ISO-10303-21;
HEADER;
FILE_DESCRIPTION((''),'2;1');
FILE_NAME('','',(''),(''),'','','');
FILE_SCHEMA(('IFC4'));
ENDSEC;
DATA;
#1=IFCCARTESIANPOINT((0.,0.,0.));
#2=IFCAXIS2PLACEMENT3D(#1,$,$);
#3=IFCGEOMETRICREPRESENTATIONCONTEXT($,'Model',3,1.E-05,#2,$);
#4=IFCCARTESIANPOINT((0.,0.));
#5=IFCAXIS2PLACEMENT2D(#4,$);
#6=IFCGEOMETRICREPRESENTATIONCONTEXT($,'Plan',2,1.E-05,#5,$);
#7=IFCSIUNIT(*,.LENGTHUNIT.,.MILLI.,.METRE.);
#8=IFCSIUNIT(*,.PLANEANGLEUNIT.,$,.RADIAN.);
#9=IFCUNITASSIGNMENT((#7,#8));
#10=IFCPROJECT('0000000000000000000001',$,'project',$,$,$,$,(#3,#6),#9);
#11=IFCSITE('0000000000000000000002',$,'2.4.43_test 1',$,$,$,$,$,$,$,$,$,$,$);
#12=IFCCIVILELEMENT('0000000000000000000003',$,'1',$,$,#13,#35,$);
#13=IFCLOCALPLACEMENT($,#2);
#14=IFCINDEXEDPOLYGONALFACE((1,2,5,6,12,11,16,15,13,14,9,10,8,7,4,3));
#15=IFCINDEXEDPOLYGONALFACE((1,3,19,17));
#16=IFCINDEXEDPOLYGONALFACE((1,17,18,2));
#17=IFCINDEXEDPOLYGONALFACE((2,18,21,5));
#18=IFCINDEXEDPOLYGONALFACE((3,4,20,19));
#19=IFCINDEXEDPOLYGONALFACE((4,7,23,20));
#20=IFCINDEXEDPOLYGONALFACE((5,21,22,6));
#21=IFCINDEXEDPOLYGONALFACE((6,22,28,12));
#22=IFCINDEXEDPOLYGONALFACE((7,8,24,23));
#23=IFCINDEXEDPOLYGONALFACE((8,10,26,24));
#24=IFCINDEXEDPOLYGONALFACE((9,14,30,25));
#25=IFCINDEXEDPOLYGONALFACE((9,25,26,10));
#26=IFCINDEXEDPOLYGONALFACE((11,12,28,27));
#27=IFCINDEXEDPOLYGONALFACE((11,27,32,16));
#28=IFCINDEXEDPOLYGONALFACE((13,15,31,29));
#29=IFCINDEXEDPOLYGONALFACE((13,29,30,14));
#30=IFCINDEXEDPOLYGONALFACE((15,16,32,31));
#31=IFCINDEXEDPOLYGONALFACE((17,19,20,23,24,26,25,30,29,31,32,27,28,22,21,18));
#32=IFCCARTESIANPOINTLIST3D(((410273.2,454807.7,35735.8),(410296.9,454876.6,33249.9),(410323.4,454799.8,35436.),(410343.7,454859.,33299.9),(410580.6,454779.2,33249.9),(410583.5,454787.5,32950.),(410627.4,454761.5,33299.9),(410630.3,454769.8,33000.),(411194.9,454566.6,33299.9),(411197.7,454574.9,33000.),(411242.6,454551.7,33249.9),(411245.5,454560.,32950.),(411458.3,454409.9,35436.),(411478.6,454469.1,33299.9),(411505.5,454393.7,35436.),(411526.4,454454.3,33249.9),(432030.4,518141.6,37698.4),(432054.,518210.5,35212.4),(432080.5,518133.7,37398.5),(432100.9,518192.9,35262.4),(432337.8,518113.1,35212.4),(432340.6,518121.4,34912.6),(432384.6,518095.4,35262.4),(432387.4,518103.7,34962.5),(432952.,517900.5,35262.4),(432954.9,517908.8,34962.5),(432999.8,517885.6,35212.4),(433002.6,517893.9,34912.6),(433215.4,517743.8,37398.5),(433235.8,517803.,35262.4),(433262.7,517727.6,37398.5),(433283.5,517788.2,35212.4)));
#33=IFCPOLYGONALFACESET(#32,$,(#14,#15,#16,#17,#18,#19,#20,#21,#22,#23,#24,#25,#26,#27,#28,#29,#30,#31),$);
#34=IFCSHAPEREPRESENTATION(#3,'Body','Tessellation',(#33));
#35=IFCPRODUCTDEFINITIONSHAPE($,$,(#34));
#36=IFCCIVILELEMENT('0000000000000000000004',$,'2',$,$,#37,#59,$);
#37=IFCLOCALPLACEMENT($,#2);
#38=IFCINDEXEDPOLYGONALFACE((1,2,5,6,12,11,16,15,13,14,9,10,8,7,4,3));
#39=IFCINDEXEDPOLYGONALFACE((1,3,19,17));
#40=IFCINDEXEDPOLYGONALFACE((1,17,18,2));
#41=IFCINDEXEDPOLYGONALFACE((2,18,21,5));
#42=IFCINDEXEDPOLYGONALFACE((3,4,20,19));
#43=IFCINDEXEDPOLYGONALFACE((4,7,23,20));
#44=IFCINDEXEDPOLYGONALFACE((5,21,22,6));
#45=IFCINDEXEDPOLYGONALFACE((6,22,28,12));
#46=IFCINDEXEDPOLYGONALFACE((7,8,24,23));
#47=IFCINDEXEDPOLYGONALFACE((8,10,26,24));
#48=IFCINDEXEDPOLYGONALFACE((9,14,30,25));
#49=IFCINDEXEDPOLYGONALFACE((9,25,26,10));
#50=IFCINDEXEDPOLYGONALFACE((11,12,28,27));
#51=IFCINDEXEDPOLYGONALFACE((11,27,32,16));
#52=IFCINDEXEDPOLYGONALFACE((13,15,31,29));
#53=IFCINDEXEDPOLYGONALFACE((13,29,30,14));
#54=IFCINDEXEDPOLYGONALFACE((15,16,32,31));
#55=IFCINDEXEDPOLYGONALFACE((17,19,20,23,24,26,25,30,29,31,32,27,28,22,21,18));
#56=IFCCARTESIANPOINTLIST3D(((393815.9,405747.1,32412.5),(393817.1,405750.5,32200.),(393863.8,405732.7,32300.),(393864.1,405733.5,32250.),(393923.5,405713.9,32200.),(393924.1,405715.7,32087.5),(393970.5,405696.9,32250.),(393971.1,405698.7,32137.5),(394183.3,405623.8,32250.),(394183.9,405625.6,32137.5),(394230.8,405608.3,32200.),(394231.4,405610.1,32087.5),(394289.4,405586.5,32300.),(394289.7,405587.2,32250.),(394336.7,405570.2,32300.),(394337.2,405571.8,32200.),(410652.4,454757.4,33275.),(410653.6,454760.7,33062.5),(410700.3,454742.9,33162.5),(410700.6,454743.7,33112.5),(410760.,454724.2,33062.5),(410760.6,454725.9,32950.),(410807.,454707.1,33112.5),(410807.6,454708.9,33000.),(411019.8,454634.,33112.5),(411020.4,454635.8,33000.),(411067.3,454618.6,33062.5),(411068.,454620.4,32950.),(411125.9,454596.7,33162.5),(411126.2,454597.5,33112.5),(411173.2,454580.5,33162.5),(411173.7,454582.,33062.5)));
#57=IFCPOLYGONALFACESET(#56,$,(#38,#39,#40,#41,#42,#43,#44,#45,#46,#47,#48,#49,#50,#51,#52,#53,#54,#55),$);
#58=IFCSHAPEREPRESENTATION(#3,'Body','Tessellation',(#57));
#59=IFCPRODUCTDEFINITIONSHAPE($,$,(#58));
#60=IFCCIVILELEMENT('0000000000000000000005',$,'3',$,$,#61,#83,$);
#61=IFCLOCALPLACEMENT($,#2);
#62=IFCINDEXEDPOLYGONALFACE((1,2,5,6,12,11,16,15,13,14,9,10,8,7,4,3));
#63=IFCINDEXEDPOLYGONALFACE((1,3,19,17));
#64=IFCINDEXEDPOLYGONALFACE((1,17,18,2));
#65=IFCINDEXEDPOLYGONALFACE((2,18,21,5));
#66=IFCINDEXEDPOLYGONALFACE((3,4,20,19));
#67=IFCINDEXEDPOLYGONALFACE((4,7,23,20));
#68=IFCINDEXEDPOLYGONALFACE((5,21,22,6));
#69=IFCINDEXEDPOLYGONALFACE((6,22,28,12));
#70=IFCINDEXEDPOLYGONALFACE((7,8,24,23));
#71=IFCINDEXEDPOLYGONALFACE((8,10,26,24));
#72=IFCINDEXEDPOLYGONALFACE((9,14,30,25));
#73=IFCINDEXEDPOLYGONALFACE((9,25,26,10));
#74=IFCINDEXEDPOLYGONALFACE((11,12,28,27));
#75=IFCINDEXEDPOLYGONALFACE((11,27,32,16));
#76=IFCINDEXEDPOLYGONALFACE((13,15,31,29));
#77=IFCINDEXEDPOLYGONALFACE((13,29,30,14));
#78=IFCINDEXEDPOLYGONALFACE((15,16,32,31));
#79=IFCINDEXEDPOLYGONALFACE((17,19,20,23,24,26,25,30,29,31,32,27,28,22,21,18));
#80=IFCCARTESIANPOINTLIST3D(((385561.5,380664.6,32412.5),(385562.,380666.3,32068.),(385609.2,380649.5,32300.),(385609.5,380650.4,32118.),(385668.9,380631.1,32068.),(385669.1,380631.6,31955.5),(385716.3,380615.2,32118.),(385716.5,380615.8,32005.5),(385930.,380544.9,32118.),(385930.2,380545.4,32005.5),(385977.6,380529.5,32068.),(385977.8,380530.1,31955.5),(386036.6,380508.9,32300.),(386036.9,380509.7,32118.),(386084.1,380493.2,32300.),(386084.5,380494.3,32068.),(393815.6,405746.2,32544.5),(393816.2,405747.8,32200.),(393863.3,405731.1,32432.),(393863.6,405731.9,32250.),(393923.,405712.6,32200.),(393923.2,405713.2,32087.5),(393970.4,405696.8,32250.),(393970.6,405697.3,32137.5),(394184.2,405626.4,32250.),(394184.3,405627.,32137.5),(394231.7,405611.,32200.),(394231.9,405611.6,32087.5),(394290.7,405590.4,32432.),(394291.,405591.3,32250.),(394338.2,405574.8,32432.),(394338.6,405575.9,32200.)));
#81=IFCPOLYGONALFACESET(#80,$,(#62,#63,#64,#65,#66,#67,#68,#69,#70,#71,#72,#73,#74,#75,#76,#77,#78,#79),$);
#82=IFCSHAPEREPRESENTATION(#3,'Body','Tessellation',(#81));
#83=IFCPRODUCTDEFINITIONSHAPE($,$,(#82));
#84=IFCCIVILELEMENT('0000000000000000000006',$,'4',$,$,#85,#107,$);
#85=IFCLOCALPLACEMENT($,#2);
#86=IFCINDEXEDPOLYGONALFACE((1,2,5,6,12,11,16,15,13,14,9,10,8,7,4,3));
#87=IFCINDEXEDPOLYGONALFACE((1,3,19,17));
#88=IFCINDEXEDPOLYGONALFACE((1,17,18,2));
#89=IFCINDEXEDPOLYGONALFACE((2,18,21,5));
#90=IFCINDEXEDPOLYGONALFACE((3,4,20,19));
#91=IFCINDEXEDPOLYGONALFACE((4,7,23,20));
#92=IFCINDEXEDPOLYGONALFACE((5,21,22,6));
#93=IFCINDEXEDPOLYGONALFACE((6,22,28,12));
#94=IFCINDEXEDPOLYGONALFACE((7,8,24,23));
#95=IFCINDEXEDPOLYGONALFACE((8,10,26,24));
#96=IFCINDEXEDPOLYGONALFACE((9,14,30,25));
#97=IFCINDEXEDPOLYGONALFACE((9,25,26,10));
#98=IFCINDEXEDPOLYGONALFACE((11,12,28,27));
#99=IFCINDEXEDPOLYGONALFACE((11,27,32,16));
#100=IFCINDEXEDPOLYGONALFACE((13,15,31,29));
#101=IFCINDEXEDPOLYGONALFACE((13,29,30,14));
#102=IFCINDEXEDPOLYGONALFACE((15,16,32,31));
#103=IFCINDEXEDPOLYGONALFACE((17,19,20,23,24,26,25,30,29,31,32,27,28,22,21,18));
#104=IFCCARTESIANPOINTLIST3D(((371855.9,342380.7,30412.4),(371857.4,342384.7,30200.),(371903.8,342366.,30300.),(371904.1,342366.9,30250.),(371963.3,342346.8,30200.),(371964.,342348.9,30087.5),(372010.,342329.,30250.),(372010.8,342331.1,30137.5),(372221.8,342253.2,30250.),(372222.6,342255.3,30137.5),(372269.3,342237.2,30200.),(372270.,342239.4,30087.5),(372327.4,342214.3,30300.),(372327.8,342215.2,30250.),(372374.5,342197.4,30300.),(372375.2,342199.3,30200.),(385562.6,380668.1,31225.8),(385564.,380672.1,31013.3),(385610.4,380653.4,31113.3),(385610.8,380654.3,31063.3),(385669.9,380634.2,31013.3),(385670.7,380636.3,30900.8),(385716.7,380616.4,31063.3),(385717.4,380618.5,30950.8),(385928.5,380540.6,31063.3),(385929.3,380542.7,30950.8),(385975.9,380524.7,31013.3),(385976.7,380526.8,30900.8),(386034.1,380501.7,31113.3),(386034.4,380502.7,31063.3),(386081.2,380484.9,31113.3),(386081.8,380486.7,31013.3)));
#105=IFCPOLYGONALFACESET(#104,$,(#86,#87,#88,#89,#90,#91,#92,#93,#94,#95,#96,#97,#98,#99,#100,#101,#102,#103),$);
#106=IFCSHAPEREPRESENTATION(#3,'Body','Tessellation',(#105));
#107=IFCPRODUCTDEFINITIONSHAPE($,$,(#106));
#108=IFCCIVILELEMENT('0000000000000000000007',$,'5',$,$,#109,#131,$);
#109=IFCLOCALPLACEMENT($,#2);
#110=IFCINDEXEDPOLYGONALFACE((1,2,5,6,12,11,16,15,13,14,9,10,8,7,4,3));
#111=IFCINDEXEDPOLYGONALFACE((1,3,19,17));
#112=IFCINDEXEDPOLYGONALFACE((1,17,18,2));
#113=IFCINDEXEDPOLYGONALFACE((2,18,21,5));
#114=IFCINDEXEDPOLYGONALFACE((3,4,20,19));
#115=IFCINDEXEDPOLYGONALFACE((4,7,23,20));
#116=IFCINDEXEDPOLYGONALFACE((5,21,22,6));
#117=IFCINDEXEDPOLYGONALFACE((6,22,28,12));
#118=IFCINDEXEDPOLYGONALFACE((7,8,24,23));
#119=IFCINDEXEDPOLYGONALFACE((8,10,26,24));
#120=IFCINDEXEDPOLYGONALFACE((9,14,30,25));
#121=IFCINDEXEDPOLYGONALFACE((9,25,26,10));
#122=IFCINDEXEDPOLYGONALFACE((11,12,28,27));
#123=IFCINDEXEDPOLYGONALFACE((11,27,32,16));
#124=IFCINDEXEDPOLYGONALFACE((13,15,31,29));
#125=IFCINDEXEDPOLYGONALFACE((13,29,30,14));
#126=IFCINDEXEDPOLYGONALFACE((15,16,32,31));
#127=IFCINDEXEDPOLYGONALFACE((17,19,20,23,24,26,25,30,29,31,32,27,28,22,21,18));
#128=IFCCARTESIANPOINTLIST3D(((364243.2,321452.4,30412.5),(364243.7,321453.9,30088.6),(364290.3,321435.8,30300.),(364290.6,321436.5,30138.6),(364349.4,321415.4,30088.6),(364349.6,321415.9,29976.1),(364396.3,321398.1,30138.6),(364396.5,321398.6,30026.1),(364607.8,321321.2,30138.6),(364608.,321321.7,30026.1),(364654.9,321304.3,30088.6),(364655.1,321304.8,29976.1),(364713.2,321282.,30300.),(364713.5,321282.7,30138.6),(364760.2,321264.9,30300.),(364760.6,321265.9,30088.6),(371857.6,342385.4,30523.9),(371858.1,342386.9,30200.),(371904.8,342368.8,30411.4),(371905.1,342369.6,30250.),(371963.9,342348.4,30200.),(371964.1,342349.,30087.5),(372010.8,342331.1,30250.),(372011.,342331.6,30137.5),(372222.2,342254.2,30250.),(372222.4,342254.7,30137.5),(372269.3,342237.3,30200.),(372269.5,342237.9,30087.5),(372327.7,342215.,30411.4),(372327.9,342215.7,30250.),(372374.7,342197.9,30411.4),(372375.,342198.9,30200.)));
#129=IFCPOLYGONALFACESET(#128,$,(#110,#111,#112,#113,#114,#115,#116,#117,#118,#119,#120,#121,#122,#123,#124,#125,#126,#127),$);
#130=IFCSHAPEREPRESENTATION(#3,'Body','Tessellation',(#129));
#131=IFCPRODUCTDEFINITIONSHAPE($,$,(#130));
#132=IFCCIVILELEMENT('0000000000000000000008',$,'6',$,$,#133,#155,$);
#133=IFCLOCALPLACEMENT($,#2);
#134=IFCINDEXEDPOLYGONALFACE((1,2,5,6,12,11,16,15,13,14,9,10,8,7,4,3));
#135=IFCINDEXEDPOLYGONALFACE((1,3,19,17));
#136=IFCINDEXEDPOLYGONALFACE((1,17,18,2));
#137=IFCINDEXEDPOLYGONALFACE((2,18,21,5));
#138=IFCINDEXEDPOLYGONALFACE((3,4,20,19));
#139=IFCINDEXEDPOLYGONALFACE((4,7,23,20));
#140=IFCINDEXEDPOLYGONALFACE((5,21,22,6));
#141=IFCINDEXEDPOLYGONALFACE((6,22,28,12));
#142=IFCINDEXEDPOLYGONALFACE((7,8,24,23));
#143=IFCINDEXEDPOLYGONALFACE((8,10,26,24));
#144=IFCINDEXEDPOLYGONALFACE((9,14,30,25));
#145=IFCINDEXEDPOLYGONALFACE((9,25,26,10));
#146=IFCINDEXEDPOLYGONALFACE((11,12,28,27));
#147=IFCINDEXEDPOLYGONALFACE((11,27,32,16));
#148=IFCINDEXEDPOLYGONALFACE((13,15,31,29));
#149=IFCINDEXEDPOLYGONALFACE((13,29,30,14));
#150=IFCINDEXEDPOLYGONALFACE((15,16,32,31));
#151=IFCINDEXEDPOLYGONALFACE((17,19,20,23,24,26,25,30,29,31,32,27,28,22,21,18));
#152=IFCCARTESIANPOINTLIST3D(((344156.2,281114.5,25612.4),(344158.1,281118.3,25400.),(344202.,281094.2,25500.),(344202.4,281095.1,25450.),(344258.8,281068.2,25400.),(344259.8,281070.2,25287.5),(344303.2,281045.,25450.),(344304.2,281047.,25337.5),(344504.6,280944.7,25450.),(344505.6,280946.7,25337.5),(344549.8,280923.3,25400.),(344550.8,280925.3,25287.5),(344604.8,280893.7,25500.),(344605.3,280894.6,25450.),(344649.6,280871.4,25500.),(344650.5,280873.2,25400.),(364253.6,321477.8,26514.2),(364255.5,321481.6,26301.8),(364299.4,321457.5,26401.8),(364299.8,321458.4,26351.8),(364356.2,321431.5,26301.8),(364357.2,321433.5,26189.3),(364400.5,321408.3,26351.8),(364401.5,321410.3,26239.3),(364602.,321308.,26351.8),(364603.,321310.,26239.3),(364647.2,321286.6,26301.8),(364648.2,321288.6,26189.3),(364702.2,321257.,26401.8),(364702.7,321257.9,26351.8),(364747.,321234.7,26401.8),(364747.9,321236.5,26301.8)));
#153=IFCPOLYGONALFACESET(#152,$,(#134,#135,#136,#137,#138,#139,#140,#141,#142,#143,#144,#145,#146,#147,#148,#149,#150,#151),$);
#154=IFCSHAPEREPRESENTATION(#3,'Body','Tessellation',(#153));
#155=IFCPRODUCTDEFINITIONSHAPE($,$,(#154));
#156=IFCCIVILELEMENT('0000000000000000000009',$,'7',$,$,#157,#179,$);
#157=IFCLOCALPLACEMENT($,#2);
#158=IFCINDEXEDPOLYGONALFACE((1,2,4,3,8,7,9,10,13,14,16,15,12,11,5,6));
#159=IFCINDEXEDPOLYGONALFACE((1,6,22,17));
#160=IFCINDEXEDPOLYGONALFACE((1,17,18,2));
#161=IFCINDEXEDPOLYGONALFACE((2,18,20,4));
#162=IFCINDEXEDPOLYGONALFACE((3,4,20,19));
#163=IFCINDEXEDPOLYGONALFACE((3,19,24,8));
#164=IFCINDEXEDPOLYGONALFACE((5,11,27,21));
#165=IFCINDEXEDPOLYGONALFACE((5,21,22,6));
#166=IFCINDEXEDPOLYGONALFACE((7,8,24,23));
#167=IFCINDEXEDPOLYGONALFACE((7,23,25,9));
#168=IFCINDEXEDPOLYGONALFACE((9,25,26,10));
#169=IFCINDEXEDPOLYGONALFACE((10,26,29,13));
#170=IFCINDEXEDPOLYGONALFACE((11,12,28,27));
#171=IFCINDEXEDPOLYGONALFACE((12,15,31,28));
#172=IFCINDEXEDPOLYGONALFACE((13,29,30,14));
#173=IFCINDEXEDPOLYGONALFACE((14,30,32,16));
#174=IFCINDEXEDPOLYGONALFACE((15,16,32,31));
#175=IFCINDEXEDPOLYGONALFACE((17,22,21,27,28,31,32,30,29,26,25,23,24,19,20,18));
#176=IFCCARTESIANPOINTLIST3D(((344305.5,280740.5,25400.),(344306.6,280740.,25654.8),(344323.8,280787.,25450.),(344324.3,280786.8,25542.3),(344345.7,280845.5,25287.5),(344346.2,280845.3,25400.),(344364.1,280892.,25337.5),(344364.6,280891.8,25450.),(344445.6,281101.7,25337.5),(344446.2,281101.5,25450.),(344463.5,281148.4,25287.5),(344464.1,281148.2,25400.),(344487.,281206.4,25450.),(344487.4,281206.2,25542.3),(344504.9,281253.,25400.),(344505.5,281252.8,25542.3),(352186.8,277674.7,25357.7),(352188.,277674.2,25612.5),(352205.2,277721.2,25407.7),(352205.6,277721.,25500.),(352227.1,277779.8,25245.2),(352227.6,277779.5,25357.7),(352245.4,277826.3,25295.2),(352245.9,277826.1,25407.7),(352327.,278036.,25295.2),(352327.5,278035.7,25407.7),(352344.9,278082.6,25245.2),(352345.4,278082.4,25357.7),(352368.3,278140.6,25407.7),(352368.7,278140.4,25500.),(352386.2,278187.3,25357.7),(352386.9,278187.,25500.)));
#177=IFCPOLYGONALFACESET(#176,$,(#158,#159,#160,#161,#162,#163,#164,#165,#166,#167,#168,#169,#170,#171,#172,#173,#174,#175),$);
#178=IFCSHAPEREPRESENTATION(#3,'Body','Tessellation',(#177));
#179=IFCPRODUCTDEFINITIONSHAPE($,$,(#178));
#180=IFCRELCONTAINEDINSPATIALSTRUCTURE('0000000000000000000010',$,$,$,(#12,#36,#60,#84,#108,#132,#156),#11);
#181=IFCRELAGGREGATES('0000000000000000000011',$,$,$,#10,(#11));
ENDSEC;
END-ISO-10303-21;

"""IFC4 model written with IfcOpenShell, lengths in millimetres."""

from ifc_helpers import new_model, si_unit, frame, origin, origin_2d, context, project, spatial, polyline, outline, extrude, element, save


model = new_model("IFC4")

# Units and contexts
model_context = context("Model", 3, precision=1e-05, world=origin())
plan_context = context("Plan", 2, precision=1e-05, world=origin_2d())
ifc_project = project(units=[si_unit("LENGTHUNIT", "METRE", prefix="MILLI"), si_unit("PLANEANGLEUNIT", "RADIAN")], contexts=[model_context, plan_context])

# Site
site = spatial("IfcSite", under=ifc_project, Name="2.4.43_test 1")

# Civil elements
element("IfcCivilElement", 1, inside=site, Name="1", context=model_context, shape_type="SweptSolid", body=[
    extrude(outline(polyline([(-600.0, 2437.0), (-600.0, 300.0), (-300.0, 300.0), (-300.0, 0.0), (300.0, 0.0), (300.0, 300.0), (600.0, 300.0), (600.0, 2437.0), (650.0, 2437.0), (650.0, 250.0), (350.0, 250.0), (350.0, -50.0), (-350.0, -50.0), (-350.0, 250.0), (-650.0, 250.0), (-650.0, 2737.0)])), frame((432671.2, 518006.3, 34962.5), z_axis=(-21757.153034, -63333.911026, -1962.54307), x_axis=(0.94575, -0.324894, 0.0)), (0.0, 0.0, 1.0), 66995.6),
])
element("IfcCivilElement", 2, inside=site, Name="2", context=model_context, shape_type="SweptSolid", body=[
    extrude(outline(polyline([(-225.0, 162.5), (-225.0, 112.5), (-112.5, 112.5), (-112.5, 0.0), (112.5, 0.0), (112.5, 112.5), (225.0, 112.5), (225.0, 162.5), (275.0, 162.5), (275.0, 62.5), (162.5, 62.5), (162.5, -50.0), (-162.5, -50.0), (-162.5, 62.5), (-275.0, 62.5), (-275.0, 275.0)])), frame((410914.0, 454672.4, 33000.0), z_axis=(-16836.530626, -49010.241873, -862.5), x_axis=(0.94575, -0.324894, 0.0)), (0.0, 0.0, 1.0), 51828.7),
])
element("IfcCivilElement", 3, inside=site, Name="3", context=model_context, shape_type="SweptSolid", body=[
    extrude(outline(polyline([(-225.0, 294.5), (-225.0, 112.5), (-112.5, 112.5), (-112.5, 0.0), (112.5, 0.0), (112.5, 112.5), (225.0, 112.5), (225.0, 294.5), (275.0, 294.5), (275.0, 62.5), (162.5, 62.5), (162.5, -50.0), (-162.5, -50.0), (-162.5, 62.5), (-275.0, 62.5), (-275.0, 407.0)])), frame((394077.5, 405662.1, 32137.5), z_axis=(-8254.121558, -25081.510599, -132.023927), x_axis=(0.949885, -0.312599, 0.0)), (0.0, 0.0, 1.0), 26405.1),
])
element("IfcCivilElement", 4, inside=site, Name="4", context=model_context, shape_type="SweptSolid", body=[
    extrude(outline(polyline([(-225.0, 162.5), (-225.0, 112.5), (-112.5, 112.5), (-112.5, 0.0), (112.5, 0.0), (112.5, 112.5), (225.0, 112.5), (225.0, 162.5), (275.0, 162.5), (275.0, 62.5), (162.5, 62.5), (162.5, -50.0), (-162.5, -50.0), (-162.5, 62.5), (-275.0, 62.5), (-275.0, 275.0)])), frame((385823.4, 380580.6, 30950.8), z_axis=(-13706.661796, -38287.424125, -813.338656), x_axis=(0.941488, -0.337047, 0.0)), (0.0, 0.0, 1.0), 40675.1),
])
element("IfcCivilElement", 5, inside=site, Name="5", context=model_context, shape_type="SweptSolid", body=[
    extrude(outline(polyline([(-225.0, 273.9), (-225.0, 112.5), (-112.5, 112.5), (-112.5, 0.0), (112.5, 0.0), (112.5, 112.5), (225.0, 112.5), (225.0, 273.9), (275.0, 273.9), (275.0, 62.5), (162.5, 62.5), (162.5, -50.0), (-162.5, -50.0), (-162.5, 62.5), (-275.0, 62.5), (-275.0, 386.4)])), frame((372116.7, 342293.2, 30137.5), z_axis=(-7614.434068, -20933.024978, -111.374497), x_axis=(0.939758, -0.341839, 0.0)), (0.0, 0.0, 1.0), 22275.2),
])
element("IfcCivilElement", 6, inside=site, Name="6", context=model_context, shape_type="SweptSolid", body=[
    extrude(outline(polyline([(-225.0, 162.5), (-225.0, 112.5), (-112.5, 112.5), (-112.5, 0.0), (112.5, 0.0), (112.5, 112.5), (225.0, 112.5), (225.0, 162.5), (275.0, 162.5), (275.0, 62.5), (162.5, 62.5), (162.5, -50.0), (-162.5, -50.0), (-162.5, 62.5), (-275.0, 62.5), (-275.0, 275.0)])), frame((364502.3, 321360.2, 26239.3), z_axis=(-20097.390539, -40363.298983, -901.798428), x_axis=(0.895173, -0.445718, 0.0)), (0.0, 0.0, 1.0), 45098.9),
])
element("IfcCivilElement", 7, inside=site, Name="7", context=model_context, shape_type="SweptSolid", body=[
    extrude(outline(polyline([(-225.0, 204.8), (-225.0, 112.5), (-112.5, 112.5), (-112.5, 0.0), (112.5, 0.0), (112.5, 112.5), (225.0, 112.5), (225.0, 204.8), (275.0, 204.8), (275.0, 62.5), (162.5, 62.5), (162.5, -50.0), (-162.5, -50.0), (-162.5, 62.5), (-275.0, 62.5), (-275.0, 317.3)])), frame((344404.9, 280996.9, 25337.5), z_axis=(7881.340978, -3065.757351, -42.283095), x_axis=(0.362528, 0.931973, 0.0)), (0.0, 0.0, 1.0), 8456.7),
])

save(model, "model.ifc")
